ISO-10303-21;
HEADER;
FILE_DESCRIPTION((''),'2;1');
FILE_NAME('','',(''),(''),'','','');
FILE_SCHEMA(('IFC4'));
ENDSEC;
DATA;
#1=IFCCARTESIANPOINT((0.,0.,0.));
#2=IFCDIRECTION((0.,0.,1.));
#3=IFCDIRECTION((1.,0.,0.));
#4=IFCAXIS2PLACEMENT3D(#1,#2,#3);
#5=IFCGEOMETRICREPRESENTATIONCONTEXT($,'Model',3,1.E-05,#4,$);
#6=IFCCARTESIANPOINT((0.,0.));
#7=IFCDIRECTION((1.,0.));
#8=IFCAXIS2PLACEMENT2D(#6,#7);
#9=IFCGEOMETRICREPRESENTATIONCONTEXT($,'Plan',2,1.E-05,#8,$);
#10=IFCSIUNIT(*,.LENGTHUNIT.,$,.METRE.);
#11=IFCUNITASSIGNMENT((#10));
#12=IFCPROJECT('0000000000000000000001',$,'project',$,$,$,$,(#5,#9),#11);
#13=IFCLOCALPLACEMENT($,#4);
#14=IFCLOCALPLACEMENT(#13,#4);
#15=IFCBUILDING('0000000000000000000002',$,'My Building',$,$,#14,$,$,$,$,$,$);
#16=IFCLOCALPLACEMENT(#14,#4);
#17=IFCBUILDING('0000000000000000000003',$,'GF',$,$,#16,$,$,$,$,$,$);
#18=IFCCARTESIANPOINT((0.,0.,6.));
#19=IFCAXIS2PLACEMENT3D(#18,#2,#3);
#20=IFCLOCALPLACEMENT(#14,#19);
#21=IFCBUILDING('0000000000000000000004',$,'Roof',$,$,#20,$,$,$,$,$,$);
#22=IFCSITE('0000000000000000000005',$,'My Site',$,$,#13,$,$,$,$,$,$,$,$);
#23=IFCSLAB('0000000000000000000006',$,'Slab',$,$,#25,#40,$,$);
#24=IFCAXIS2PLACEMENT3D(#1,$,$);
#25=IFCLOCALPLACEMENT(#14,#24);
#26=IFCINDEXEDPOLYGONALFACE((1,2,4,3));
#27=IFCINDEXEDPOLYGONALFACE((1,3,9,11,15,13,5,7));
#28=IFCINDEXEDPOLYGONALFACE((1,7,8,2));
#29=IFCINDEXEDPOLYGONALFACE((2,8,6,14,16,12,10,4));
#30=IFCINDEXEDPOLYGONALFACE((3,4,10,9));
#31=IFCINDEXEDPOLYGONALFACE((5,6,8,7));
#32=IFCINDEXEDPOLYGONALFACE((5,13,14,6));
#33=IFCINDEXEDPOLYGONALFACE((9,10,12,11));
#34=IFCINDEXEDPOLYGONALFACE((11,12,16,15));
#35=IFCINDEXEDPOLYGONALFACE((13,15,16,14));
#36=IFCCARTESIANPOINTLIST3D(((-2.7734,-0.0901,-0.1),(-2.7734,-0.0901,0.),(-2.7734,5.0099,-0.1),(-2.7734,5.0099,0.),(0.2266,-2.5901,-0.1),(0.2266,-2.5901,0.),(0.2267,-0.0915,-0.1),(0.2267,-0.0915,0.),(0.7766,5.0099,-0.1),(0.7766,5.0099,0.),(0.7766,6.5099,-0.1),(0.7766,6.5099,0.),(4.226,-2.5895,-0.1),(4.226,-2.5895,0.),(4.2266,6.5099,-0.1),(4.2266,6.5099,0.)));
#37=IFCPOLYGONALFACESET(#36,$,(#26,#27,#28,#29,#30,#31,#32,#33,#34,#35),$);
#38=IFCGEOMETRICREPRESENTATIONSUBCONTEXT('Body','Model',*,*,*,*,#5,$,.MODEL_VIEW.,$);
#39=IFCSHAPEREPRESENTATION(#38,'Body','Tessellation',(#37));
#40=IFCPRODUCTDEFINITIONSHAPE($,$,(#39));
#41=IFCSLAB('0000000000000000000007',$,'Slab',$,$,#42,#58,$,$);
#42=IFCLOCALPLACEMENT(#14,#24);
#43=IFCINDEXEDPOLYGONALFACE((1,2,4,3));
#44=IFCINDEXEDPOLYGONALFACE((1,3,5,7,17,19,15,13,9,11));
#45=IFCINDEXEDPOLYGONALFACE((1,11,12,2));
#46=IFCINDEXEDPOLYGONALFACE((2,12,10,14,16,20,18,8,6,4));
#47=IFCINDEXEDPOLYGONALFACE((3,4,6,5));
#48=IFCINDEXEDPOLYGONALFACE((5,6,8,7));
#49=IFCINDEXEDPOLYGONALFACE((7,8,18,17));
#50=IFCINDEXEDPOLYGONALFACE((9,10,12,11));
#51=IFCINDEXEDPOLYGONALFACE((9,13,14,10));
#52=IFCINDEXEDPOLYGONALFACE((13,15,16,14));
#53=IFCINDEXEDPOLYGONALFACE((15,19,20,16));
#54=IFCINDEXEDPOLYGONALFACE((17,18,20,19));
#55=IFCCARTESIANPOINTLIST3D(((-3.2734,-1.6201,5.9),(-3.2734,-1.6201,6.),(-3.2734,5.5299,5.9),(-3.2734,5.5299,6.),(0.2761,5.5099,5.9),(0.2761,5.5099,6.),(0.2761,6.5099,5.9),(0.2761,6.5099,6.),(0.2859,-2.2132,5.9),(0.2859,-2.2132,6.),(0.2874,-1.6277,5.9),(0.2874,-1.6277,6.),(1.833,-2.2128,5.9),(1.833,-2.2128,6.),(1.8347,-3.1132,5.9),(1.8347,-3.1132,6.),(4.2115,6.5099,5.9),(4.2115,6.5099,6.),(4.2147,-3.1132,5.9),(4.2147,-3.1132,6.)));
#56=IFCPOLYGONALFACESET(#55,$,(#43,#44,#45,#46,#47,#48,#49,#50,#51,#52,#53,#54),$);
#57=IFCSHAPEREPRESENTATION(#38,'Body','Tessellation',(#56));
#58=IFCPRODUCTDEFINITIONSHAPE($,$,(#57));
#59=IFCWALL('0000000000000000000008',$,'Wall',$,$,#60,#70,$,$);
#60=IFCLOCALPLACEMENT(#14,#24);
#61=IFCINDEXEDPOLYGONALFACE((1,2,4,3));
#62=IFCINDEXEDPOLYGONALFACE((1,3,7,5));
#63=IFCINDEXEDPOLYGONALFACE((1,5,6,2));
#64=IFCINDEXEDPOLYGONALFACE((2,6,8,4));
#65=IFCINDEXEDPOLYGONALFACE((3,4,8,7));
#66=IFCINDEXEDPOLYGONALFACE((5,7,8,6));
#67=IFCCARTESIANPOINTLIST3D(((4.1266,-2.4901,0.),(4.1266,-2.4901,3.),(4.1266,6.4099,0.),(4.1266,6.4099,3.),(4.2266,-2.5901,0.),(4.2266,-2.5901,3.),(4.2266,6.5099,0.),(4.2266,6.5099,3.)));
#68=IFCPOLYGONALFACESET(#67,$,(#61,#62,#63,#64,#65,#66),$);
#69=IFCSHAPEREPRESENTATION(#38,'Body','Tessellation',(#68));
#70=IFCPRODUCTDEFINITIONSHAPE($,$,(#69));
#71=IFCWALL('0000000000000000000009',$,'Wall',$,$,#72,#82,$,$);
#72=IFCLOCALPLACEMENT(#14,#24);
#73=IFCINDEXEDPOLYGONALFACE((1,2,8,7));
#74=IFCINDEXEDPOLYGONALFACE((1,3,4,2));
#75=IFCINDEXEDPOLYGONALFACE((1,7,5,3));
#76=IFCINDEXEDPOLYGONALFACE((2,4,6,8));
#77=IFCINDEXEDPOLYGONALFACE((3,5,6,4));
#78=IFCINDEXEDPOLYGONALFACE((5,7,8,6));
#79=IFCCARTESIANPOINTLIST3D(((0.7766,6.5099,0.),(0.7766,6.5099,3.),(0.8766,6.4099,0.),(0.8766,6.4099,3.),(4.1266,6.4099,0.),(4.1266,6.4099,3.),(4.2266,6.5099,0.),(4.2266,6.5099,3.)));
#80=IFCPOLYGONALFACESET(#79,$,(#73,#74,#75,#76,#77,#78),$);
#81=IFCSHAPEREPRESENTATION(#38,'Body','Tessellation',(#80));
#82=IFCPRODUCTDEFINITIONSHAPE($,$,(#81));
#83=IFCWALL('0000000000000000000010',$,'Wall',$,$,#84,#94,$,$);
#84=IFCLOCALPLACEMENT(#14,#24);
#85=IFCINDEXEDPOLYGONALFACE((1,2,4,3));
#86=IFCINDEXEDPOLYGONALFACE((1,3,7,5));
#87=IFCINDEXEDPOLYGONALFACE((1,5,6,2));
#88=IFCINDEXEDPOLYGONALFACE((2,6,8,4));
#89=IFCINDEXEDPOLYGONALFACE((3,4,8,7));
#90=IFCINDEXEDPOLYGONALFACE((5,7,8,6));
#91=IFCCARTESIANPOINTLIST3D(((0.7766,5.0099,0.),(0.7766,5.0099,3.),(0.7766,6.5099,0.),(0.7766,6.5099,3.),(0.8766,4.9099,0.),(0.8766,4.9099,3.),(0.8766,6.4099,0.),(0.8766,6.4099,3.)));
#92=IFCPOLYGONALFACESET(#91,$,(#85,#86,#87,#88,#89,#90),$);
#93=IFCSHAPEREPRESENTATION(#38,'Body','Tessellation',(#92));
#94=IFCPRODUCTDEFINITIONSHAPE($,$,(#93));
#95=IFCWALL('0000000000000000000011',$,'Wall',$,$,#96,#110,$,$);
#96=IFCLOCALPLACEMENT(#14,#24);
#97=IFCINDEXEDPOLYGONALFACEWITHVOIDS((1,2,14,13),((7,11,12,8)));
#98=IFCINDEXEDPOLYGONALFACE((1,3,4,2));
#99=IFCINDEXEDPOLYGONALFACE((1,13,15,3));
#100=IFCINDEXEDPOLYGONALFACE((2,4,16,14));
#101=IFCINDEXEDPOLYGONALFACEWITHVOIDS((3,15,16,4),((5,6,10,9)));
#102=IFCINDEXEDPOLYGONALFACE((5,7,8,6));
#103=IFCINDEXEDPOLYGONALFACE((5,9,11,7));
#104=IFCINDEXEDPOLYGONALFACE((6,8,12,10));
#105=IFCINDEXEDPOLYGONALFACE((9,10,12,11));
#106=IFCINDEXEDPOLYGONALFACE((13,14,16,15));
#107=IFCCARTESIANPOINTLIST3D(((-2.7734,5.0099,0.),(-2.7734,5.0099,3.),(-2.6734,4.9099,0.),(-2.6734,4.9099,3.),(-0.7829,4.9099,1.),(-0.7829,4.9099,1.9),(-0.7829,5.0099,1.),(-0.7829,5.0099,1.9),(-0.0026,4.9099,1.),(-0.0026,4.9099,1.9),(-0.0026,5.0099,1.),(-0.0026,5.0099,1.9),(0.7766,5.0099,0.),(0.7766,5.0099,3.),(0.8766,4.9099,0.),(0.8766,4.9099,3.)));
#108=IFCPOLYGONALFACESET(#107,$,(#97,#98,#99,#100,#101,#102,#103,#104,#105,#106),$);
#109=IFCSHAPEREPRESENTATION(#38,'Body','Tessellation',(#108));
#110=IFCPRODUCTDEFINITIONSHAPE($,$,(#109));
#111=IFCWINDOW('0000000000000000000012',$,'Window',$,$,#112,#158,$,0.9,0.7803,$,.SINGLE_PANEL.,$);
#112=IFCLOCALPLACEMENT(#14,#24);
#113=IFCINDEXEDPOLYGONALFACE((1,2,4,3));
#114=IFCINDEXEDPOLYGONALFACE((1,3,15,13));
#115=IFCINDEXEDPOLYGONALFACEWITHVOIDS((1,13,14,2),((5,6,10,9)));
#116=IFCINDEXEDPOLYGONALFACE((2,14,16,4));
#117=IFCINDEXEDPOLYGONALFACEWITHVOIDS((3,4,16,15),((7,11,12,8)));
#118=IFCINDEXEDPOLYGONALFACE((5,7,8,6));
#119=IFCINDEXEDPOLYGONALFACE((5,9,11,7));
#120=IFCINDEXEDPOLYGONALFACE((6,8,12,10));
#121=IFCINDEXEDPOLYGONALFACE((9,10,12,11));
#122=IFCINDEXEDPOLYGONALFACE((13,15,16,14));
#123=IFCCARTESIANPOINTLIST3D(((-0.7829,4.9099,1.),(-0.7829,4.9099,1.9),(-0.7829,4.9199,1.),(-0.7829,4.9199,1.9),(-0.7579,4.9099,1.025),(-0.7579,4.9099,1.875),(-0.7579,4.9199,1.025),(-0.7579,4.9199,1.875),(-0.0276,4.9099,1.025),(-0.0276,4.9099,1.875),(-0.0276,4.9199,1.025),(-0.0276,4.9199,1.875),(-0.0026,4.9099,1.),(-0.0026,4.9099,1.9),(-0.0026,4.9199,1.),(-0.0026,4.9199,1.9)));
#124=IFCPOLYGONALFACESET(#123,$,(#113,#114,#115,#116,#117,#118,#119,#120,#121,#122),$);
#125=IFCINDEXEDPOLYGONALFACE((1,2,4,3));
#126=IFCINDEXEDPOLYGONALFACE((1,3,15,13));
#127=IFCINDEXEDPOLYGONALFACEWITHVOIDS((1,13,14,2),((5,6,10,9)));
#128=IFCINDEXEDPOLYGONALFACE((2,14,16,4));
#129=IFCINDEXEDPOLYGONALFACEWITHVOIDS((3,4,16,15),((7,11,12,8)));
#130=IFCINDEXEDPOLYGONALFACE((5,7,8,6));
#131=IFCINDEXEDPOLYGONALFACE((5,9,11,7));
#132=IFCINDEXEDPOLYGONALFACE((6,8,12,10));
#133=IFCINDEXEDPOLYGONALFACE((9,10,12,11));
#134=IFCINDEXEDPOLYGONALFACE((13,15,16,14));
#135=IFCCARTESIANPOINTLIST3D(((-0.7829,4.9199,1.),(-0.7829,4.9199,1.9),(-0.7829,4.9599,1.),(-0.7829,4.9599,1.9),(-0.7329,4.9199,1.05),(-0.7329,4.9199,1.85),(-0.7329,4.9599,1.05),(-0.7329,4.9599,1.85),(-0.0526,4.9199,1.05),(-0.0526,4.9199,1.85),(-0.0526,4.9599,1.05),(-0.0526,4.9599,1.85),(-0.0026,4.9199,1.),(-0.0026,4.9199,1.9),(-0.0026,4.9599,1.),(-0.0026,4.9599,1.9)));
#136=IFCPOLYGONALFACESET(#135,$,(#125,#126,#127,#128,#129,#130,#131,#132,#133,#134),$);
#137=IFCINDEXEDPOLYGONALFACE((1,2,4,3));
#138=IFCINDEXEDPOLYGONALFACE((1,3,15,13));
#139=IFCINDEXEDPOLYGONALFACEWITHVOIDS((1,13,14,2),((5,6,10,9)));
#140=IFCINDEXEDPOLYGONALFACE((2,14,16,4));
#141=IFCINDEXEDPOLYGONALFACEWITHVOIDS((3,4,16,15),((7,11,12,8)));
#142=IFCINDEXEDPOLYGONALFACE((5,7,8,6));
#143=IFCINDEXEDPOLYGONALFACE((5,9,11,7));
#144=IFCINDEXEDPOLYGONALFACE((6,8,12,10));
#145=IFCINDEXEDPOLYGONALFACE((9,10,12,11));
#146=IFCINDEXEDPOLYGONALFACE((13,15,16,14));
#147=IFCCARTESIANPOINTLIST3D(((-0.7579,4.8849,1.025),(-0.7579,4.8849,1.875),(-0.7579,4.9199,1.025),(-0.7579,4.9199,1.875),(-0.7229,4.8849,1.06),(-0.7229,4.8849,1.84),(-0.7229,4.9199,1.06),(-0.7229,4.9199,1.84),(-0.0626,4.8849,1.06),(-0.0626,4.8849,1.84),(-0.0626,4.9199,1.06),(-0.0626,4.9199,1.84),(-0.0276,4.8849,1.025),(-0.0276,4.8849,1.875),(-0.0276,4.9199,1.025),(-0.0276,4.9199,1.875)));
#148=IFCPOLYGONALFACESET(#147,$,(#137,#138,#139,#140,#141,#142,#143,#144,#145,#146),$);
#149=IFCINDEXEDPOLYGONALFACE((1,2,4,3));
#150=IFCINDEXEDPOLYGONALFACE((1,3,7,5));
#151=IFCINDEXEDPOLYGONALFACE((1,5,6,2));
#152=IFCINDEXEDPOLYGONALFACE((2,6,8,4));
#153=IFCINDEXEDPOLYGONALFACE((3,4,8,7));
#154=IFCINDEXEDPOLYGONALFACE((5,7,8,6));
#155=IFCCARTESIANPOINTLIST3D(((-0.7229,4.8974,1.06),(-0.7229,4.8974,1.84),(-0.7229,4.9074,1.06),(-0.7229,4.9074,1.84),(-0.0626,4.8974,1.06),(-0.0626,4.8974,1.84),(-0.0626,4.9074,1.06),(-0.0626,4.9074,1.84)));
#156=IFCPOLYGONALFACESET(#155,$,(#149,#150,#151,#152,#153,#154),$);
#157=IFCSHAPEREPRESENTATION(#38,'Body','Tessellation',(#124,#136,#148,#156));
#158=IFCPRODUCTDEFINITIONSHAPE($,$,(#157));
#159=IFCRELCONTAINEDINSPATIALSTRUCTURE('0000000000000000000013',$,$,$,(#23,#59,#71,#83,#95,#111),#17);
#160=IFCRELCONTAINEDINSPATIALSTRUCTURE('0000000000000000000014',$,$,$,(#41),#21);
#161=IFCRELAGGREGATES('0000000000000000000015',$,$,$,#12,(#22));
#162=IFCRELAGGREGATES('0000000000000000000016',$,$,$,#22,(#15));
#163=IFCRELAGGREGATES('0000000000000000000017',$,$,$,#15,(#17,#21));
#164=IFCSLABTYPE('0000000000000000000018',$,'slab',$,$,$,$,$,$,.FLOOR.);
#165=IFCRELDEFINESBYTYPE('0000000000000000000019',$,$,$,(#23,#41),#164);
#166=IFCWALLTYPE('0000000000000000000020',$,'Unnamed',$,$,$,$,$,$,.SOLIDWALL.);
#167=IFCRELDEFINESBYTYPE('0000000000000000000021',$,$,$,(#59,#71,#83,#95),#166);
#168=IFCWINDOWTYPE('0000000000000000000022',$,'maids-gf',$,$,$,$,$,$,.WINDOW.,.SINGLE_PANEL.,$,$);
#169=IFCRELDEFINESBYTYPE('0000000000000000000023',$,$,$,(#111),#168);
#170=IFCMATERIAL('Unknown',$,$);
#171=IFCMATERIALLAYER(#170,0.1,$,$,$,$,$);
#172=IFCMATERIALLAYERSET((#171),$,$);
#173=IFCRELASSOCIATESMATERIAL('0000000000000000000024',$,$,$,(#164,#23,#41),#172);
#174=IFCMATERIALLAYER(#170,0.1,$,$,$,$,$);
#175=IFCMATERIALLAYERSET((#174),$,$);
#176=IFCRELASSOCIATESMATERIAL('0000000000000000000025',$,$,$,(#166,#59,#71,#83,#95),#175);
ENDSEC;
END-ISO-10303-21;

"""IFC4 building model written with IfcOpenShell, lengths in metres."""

from ifc_helpers import new_model, entity, si_unit, frame, origin_with_axes, origin_2d_with_axis, place, context, subcontext, project, spatial, line, indexed_curve, outline, extrude, shape, source, transform, mapped, material, layer, layer_set, layer_usage, type_object, type_shapes, element, fill, save


model = new_model("IFC4")

# Units and contexts
model_context = context("Model", 3, precision=1e-05, world=origin_with_axes())
plan_context = context("Plan", 2, precision=1e-05, world=origin_2d_with_axis())
body_context_1 = subcontext(model_context, "Body", "Model", "MODEL_VIEW")
body_context_2 = subcontext(plan_context, "Body", "Plan", "PLAN_VIEW")
ifc_project = project(units=[si_unit("LENGTHUNIT", "METRE")], contexts=[model_context, plan_context])

# Site, buildings
site_placement = place(None, origin_with_axes())
site = spatial("IfcSite", under=ifc_project, at=site_placement, Name="My Site")
building_1_placement = place(site_placement, origin_with_axes())
building_1 = spatial("IfcBuilding", under=site, at=building_1_placement, Name="My Building")
building_2_placement = place(building_1_placement, origin_with_axes())
building_2 = spatial("IfcBuilding", under=building_1, at=building_2_placement, Name="GF")

# Slab
ifc_material = material(Name="Unknown")
ifc_layer_1 = layer(ifc_material, 0.1)
ifc_layer_set_1 = layer_set([ifc_layer_1])
ifc_layer_usage_1 = layer_usage(ifc_layer_set_1, "AXIS3", "POSITIVE", -0.1)
slab_type = type_object("IfcSlabType", Name="slab", PredefinedType="FLOOR", material=ifc_layer_set_1)
slab_1_placement = place(building_2_placement, frame((4.2266, 6.5099, 0.0), z_axis=(0.0, 0.0, 1.0), x_axis=(1.0, 0.0, 0.0)))
element("IfcSlab", 1, at=slab_1_placement, inside=building_2, type_object=slab_type, material=ifc_layer_usage_1, Name="Slab", context=body_context_1, shape_type="SweptSolid", body=[
    extrude(outline(indexed_curve([(0.0, 0.0), (-3.45, 0.0), (-3.45, -1.5), (-7.0, -1.5), (-7.0, -6.6), (-3.9999, -6.6014), (-4.0, -9.1), (-0.0006, -9.0994), (0.0, 0.0)])), frame((0.0, 0.0, -0.1), z_axis=(0.0, 0.0, 1.0), x_axis=(1.0, 0.0, 0.0)), (0.0, 0.0, 1.0), 0.1),
])

# Shared definitions
building_3_placement = place(building_1_placement, frame((0.0, 0.0, 6.0), z_axis=(0.0, 0.0, 1.0), x_axis=(1.0, 0.0, 0.0)))
building_3 = spatial("IfcBuilding", under=building_1, at=building_3_placement, Name="Roof")

# Slab
ifc_layer_usage_2 = layer_usage(ifc_layer_set_1, "AXIS3", "POSITIVE", -0.1)
slab_2_placement = place(building_3_placement, frame((4.2115, 6.5099, 0.0), z_axis=(0.0, 0.0, 1.0), x_axis=(1.0, 0.0, 0.0)))
element("IfcSlab", 2, at=slab_2_placement, inside=building_3, type_object=slab_type, material=ifc_layer_usage_2, Name="Slab", context=body_context_1, shape_type="SweptSolid", body=[
    extrude(outline(indexed_curve([(0.0, 0.0), (-3.9355, 0.0), (-3.9355, -1.0), (-7.4849, -0.98), (-7.4849, -8.13), (-3.9241, -8.1376), (-3.9257, -8.7231), (-2.3785, -8.7227), (-2.3768, -9.6231), (0.0032, -9.6231), (0.0, 0.0)])), frame((0.0, 0.0, -0.1), z_axis=(0.0, 0.0, 1.0), x_axis=(1.0, 0.0, 0.0)), (0.0, 0.0, 1.0), 0.1),
])

# Shared definitions
ifc_layer_2 = layer(ifc_material, 0.1)
ifc_layer_set_2 = layer_set([ifc_layer_2])
wall_type = type_object("IfcWallType", Name="Unnamed", PredefinedType="SOLIDWALL", material=ifc_layer_set_2)

# Walls
ifc_layer_usage_3 = layer_usage(ifc_layer_set_2, "AXIS2", "POSITIVE", 0.0)
wall_1_placement = place(building_2_placement, frame((4.2266, -2.5901, 0.0), z_axis=(0.0, 0.0, 1.0), x_axis=(0.0, 1.0, 0.0)))
element("IfcWall", 3, at=wall_1_placement, inside=building_2, type_object=wall_type, material=ifc_layer_usage_3, Name="Wall", context=body_context_1, shape_type="SweptSolid", body=[
    extrude(outline(indexed_curve([(0.0, 0.0), (0.1, 0.1), (9.0, 0.1), (9.1, 0.0)], segments=[line(1, 2, 3, 4, 1)])), origin_with_axes(), (0.0, 0.0, 1.0), 3.0),
])
ifc_layer_usage_4 = layer_usage(ifc_layer_set_2, "AXIS2", "POSITIVE", 0.0)
wall_2_placement = place(building_2_placement, frame((4.2266, 6.5099, 0.0), z_axis=(0.0, 0.0, 1.0), x_axis=(-1.0, 0.0, 0.0)))
element("IfcWall", 4, at=wall_2_placement, inside=building_2, type_object=wall_type, material=ifc_layer_usage_4, Name="Wall", context=body_context_1, shape_type="SweptSolid", body=[
    extrude(outline(indexed_curve([(0.0, 0.0), (0.1, 0.1), (3.35, 0.1), (3.45, 0.0)], segments=[line(1, 2, 3, 4, 1)])), origin_with_axes(), (0.0, 0.0, 1.0), 3.0),
])
ifc_layer_usage_5 = layer_usage(ifc_layer_set_2, "AXIS2", "POSITIVE", 0.0)
wall_3_placement = place(building_2_placement, frame((0.7766, 6.5099, 0.0), z_axis=(0.0, 0.0, 1.0), x_axis=(0.0, -1.0, 0.0)))
element("IfcWall", 5, at=wall_3_placement, inside=building_2, type_object=wall_type, material=ifc_layer_usage_5, Name="Wall", context=body_context_1, shape_type="SweptSolid", body=[
    extrude(outline(indexed_curve([(0.0, 0.0), (0.1, 0.1), (1.6, 0.1), (1.5, 0.0)], segments=[line(1, 2, 3, 4, 1)])), origin_with_axes(), (0.0, 0.0, 1.0), 3.0),
])

# Wall, opening, window
ifc_layer_usage_6 = layer_usage(ifc_layer_set_2, "AXIS2", "POSITIVE", 0.0)
wall_4_placement = place(building_2_placement, frame((0.7766, 5.0099, 0.0), z_axis=(0.0, 0.0, 1.0), x_axis=(-1.0, 0.0, 0.0)))
wall_4 = element("IfcWall", 6, at=wall_4_placement, inside=building_2, type_object=wall_type, material=ifc_layer_usage_6, Name="Wall", context=body_context_1, shape_type="SweptSolid", body=[
    extrude(outline(indexed_curve([(0.0, 0.0), (-0.1, 0.1), (3.45, 0.1), (3.55, 0.0)], segments=[line(1, 2, 3, 4, 1)])), origin_with_axes(), (0.0, 0.0, 1.0), 3.0),
])
shared_shape_1 = source(origin_with_axes(), body_context_1, "Body", "SweptSolid", [
    extrude(outline(indexed_curve([(0.0, 0.0), (0.7803, 0.0), (0.7803, 0.9), (0.0, 0.9)], segments=[line(1, 2, 3, 4, 1)])), frame((0.0, -0.6, 0.0), z_axis=(0.0, -1.0, 0.0), x_axis=(1.0, 0.0, 0.0)), (0.0, 0.0, -1.0), 1.2),
])
opening_1_placement = place(wall_4_placement, frame((0.7792, 0.0, 1.0), z_axis=(0.0, 0.0, 1.0), x_axis=(1.0, 0.0, 0.0)))
opening_1 = element("IfcOpeningElement", 7, at=opening_1_placement, cuts=wall_4, PredefinedType="OPENING", context=body_context_1, shape_type="MappedRepresentation", body=[
    mapped(shared_shape_1, transform((0.0, 0.0, 0.0), x_axis=(1.0, 0.0, 0.0), y_axis=(0.0, 1.0, 0.0), z_axis=(0.0, 0.0, 1.0), scale=1.0)),
])
window_type_1 = type_object("IfcWindowType", Name="maids-gf", PartitioningType="SINGLE_PANEL", PredefinedType="WINDOW")
shared_shape_2 = source(origin_with_axes(), body_context_1, "Body", "SweptSolid", [
    extrude(outline(indexed_curve([(0.0, 0.0), (0.7803, 0.0), (0.7803, 0.9), (0.0, 0.9)], segments=[line(1, 2, 3, 4, 1)]), holes=[indexed_curve([(0.025, 0.025), (0.7553, 0.025), (0.7553, 0.875), (0.025, 0.875)], segments=[line(1, 2, 3, 4, 1)])]), frame((0.0, 0.09, 0.0), z_axis=(0.0, -1.0, 0.0), x_axis=(1.0, 0.0, 0.0)), (0.0, 0.0, -1.0), 0.01),
    extrude(outline(indexed_curve([(0.0, 0.0), (0.7803, 0.0), (0.7803, 0.9), (0.0, 0.9)], segments=[line(1, 2, 3, 4, 1)]), holes=[indexed_curve([(0.05, 0.05), (0.7303, 0.05), (0.7303, 0.85), (0.05, 0.85)], segments=[line(1, 2, 3, 4, 1)])]), frame((0.0, 0.05, 0.0), z_axis=(0.0, -1.0, 0.0), x_axis=(1.0, 0.0, 0.0)), (0.0, 0.0, -1.0), 0.04),
    extrude(outline(indexed_curve([(0.0, 0.0), (0.7303, 0.0), (0.7303, 0.85), (0.0, 0.85)], segments=[line(1, 2, 3, 4, 1)]), holes=[indexed_curve([(0.035, 0.035), (0.6953, 0.035), (0.6953, 0.815), (0.035, 0.815)], segments=[line(1, 2, 3, 4, 1)])]), frame((0.025, 0.09, 0.025), z_axis=(0.0, -1.0, 0.0), x_axis=(1.0, 0.0, 0.0)), (0.0, 0.0, -1.0), 0.035),
    extrude(outline(indexed_curve([(0.035, 0.035), (0.6953, 0.035), (0.6953, 0.815), (0.035, 0.815)], segments=[line(1, 2, 3, 4, 1)])), frame((0.025, 0.1025, 0.025), z_axis=(0.0, -1.0, 0.0), x_axis=(1.0, 0.0, 0.0)), (0.0, 0.0, -1.0), 0.01),
])
shared_shape_3 = source(origin_with_axes(), body_context_2, "Body", "Curve2D", [
    entity("IfcIndexedPolyCurve", entity("IfcCartesianPointList2D", [[0.05, 0.05], [0.7303, 0.05]])),
    entity("IfcIndexedPolyCurve", entity("IfcCartesianPointList2D", [[0.0, 0.1], [0.025, 0.1], [0.025, 0.09], [0.05, 0.09], [0.05, 0.05], [0.0, 0.05]]), [entity("IfcLineIndex", [1, 2, 3, 4, 5, 6, 1])]),
    entity("IfcIndexedPolyCurve", entity("IfcCartesianPointList2D", [[0.7803, 0.1], [0.7553, 0.1], [0.7553, 0.09], [0.7303, 0.09], [0.7303, 0.05], [0.7803, 0.05]]), [entity("IfcLineIndex", [1, 2, 3, 4, 5, 6, 1])]),
    entity("IfcIndexedPolyCurve", entity("IfcCartesianPointList2D", [[0.025, 0.09], [0.06, 0.09], [0.06, 0.125], [0.025, 0.125]]), [entity("IfcLineIndex", [1, 2, 3, 4, 1])]),
    entity("IfcIndexedPolyCurve", entity("IfcCartesianPointList2D", [[0.7553, 0.09], [0.7203, 0.09], [0.7203, 0.125], [0.7553, 0.125]]), [entity("IfcLineIndex", [1, 2, 3, 4, 1])]),
    entity("IfcIndexedPolyCurve", entity("IfcCartesianPointList2D", [[0.06, 0.09], [0.7203, 0.09]])),
    entity("IfcIndexedPolyCurve", entity("IfcCartesianPointList2D", [[0.06, 0.125], [0.7203, 0.125]])),
    entity("IfcIndexedPolyCurve", entity("IfcCartesianPointList2D", [[0.06, 0.1075], [0.7203, 0.1075]])),
])
type_shapes(window_type_1, [shared_shape_2, shared_shape_3])
window_1_placement = place(opening_1_placement, frame((0.0, 0.0, 0.0), z_axis=(0.0, 0.0, 1.0), x_axis=(1.0, 0.0, 0.0)))
window_1 = element("IfcWindow", 8, at=window_1_placement, inside=building_2, type_object=window_type_1, Name="Window", OverallHeight=0.9, OverallWidth=0.7803, PartitioningType="SINGLE_PANEL", shapes=[
    shape(body_context_1, "Body", "MappedRepresentation", [mapped(shared_shape_2, transform((0.0, 0.0, 0.0), x_axis=(1.0, 0.0, 0.0), y_axis=(0.0, 1.0, 0.0), z_axis=(0.0, 0.0, 1.0), scale=1.0))]),
    shape(body_context_2, "Body", "MappedRepresentation", [mapped(shared_shape_3, transform((0.0, 0.0, 0.0), x_axis=(1.0, 0.0, 0.0), y_axis=(0.0, 1.0, 0.0), z_axis=(0.0, 0.0, 1.0), scale=1.0))]),
])
fill(opening_1, window_1)

save(model, "model.ifc")
